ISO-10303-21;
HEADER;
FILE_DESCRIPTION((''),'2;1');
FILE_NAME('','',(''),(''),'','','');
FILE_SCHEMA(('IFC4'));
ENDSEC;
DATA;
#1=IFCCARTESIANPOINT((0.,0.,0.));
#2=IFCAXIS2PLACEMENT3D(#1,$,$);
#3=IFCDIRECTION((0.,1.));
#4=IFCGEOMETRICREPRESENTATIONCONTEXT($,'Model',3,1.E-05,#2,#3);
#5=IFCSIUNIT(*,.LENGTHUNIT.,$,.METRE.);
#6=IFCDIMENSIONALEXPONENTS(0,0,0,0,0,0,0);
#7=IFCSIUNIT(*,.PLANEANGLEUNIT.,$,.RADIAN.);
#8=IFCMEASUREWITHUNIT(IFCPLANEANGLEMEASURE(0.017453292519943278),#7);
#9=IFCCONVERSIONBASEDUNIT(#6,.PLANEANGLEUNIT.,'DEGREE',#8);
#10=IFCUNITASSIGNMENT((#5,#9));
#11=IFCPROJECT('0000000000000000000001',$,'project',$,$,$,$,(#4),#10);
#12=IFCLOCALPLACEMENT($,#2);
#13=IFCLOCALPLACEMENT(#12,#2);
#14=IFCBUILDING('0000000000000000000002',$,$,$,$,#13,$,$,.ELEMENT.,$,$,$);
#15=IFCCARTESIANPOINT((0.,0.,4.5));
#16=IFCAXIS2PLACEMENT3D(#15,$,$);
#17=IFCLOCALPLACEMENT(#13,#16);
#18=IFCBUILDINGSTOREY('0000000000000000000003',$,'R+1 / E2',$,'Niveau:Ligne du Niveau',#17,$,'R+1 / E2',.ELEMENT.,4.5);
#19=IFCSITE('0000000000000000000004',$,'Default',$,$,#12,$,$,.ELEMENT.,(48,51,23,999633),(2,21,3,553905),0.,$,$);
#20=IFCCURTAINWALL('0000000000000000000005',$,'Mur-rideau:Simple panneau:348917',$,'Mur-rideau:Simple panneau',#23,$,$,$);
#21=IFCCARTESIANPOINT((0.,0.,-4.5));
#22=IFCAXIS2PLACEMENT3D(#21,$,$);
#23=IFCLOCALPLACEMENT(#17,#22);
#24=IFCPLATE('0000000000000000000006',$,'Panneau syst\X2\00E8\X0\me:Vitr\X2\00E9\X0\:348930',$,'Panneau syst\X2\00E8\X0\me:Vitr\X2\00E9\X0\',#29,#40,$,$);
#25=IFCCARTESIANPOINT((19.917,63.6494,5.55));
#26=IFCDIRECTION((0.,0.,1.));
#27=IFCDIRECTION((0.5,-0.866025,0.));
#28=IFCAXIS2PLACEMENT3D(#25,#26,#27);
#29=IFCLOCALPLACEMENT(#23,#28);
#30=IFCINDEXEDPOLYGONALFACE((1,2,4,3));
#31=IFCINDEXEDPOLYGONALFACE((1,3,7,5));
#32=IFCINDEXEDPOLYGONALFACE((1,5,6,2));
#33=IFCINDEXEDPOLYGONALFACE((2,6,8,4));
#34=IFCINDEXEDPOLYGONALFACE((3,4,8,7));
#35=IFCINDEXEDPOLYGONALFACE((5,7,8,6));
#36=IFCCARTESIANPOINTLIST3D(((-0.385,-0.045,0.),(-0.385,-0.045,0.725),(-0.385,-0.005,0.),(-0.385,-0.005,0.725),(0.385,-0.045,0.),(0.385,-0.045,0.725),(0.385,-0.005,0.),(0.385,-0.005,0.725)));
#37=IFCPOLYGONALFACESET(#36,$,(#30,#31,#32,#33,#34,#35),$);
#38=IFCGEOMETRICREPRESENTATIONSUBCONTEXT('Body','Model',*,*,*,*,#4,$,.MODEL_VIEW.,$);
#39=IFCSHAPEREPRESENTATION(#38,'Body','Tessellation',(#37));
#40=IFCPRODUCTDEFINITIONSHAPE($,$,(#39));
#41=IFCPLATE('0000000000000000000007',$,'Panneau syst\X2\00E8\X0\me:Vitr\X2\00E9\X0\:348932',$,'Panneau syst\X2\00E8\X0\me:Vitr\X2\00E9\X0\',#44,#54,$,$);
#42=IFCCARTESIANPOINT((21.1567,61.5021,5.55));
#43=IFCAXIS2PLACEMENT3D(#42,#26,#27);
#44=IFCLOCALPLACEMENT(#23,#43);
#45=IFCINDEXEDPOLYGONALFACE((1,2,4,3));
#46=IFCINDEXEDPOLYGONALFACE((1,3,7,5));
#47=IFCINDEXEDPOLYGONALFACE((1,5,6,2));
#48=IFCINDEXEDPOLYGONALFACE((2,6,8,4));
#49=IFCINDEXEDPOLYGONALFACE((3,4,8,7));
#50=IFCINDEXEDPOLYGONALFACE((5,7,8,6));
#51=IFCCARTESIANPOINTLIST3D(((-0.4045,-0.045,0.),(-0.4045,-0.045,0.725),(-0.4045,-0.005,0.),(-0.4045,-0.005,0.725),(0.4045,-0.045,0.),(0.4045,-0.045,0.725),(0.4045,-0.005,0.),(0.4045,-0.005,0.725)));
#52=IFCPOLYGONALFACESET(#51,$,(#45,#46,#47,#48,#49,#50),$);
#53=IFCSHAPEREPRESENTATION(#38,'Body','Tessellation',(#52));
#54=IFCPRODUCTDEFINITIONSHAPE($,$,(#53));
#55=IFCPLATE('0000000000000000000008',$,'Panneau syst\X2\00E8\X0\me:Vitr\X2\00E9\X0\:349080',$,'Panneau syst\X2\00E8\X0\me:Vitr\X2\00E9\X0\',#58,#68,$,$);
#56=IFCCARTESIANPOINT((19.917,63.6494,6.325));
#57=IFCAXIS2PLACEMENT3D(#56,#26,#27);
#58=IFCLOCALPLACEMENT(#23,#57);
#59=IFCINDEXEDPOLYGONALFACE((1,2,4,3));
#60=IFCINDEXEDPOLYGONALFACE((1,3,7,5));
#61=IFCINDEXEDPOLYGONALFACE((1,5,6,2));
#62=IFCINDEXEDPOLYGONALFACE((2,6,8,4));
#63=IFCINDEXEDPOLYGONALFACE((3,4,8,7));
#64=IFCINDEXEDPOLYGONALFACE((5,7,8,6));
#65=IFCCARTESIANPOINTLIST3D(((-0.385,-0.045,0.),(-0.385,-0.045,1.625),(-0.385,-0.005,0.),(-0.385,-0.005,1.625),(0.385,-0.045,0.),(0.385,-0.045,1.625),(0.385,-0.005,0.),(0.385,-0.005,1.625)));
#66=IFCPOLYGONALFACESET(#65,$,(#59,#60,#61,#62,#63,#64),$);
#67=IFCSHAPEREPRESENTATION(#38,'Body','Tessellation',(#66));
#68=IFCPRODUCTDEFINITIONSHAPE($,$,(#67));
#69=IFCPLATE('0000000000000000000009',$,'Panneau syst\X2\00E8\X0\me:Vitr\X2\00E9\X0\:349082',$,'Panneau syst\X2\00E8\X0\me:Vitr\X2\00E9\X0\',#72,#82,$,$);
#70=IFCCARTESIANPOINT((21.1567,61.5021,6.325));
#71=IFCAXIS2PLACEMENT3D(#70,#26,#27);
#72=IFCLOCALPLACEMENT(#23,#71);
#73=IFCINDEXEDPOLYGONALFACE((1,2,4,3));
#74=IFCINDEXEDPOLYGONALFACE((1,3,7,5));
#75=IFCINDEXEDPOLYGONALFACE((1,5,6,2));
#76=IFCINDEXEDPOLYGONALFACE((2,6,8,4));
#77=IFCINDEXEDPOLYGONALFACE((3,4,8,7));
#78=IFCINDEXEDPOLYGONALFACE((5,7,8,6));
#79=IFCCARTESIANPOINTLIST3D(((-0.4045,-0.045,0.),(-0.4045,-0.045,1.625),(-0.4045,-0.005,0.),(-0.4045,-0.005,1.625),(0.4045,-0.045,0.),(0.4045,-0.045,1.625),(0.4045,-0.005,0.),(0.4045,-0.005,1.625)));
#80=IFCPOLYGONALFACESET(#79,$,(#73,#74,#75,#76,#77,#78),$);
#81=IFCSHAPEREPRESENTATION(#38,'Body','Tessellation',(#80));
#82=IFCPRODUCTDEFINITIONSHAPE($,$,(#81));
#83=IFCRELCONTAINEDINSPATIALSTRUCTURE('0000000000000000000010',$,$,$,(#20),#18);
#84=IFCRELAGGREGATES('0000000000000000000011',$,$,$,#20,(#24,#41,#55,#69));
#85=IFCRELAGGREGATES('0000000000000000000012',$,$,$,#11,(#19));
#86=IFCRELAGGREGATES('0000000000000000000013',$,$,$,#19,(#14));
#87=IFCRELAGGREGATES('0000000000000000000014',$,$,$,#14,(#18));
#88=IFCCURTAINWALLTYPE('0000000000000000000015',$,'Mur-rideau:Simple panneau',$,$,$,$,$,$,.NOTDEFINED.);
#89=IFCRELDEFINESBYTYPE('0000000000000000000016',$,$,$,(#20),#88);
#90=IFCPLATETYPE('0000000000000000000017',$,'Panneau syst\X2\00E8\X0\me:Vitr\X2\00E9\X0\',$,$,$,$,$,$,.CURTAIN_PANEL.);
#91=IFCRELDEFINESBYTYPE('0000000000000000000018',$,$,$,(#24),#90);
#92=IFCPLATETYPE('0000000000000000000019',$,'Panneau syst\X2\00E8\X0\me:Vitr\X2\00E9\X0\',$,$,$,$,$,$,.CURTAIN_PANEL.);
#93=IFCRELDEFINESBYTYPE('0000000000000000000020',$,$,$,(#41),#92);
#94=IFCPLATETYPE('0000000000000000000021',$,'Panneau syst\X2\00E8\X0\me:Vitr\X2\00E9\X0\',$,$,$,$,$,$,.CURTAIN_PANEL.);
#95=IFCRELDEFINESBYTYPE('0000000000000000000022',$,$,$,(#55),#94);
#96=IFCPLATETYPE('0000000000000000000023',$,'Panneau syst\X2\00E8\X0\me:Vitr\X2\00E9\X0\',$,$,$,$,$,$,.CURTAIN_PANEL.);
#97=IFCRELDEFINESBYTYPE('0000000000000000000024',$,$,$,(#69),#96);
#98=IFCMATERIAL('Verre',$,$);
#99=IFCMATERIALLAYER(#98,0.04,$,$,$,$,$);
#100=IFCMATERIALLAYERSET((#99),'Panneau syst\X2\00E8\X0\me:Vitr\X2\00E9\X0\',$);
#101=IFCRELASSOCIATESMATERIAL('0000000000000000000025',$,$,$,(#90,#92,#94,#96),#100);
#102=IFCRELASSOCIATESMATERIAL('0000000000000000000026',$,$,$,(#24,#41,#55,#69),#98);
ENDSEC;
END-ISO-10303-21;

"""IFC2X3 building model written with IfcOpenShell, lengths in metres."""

from ifc_helpers import new_model, entity, si_unit, converted_unit, direction, frame, frame_2d, origin, place, context, subcontext, project, spatial, rectangle, extrude, source, transform, mapped, material, layer, layer_set, type_object, type_shapes, element, aggregate, save


model = new_model("IFC2X3")

# Units and contexts
model_context = context("Model", 3, precision=1e-05, world=origin(), true_north=direction((0.0, 1.0)))
body_context = subcontext(model_context, "Body", "Model", "MODEL_VIEW")
ifc_project = project(units=[si_unit("LENGTHUNIT", "METRE"), converted_unit("PLANEANGLEUNIT", "DEGREE", entity("IfcPlaneAngleMeasure", 0.017453292519943278), si_unit("PLANEANGLEUNIT", "RADIAN"), dimensions=[0, 0, 0, 0, 0, 0, 0])], contexts=[model_context])

# Site, building, storey
site_placement = place(None, origin())
site = spatial("IfcSite", under=ifc_project, at=site_placement, Name="Default", CompositionType="ELEMENT", RefLatitude=(48, 51, 23, 999633), RefLongitude=(2, 21, 3, 553905), RefElevation=0.0)
building_placement = place(site_placement, origin())
building = spatial("IfcBuilding", under=site, at=building_placement, CompositionType="ELEMENT")
storey_placement = place(building_placement, frame((0.0, 0.0, 4.5)))
storey = spatial("IfcBuildingStorey", under=building, at=storey_placement, Name="R+1 / E2", ObjectType="Niveau:Ligne du Niveau", LongName="R+1 / E2", CompositionType="ELEMENT", Elevation=4.5)

# Curtain wall
curtain_wall_type = type_object("IfcCurtainWallType", Name="Mur-rideau:Simple panneau", PredefinedType="NOTDEFINED")
curtain_wall_1_placement = place(storey_placement, frame((0.0, 0.0, -4.5)))
curtain_wall_1 = element("IfcCurtainWall", 1, at=curtain_wall_1_placement, inside=storey, type_object=curtain_wall_type, Name="Mur-rideau:Simple panneau:348917", ObjectType="Mur-rideau:Simple panneau")

# Plates
ifc_material_1 = material(Name="Verre")
ifc_layer_1 = layer(ifc_material_1, 0.04)
ifc_layer_set_1 = layer_set([ifc_layer_1], Name="Panneau système:Vitré")
plate_type_1 = type_object("IfcPlateType", Name="Panneau système:Vitré", PredefinedType="CURTAIN_PANEL", material=ifc_layer_set_1)
shared_shape_1 = source(origin(), body_context, "Body", "SweptSolid", [
    extrude(rectangle(XDim=0.04, YDim=0.77, at=frame_2d((0.0, 0.0), x_axis=(1.0, 0.0))), frame((0.0, -0.025, 0.0), z_axis=(0.0, 0.0, 1.0), x_axis=(0.0, 1.0, 0.0)), (0.0, 0.0, 1.0), 0.725),
])
type_shapes(plate_type_1, [shared_shape_1])
plate_1_placement = place(curtain_wall_1_placement, frame((19.917, 63.6494, 5.55), z_axis=(0.0, 0.0, 1.0), x_axis=(0.5, -0.866025, 0.0)))
plate_1 = element("IfcPlate", 2, at=plate_1_placement, type_object=plate_type_1, material=ifc_material_1, Name="Panneau système:Vitré:348930", ObjectType="Panneau système:Vitré", context=body_context, shape_type="MappedRepresentation", body=[
    mapped(shared_shape_1, transform((0.0, 0.0, 0.0), scale=1.0)),
])
plate_type_2 = type_object("IfcPlateType", Name="Panneau système:Vitré", PredefinedType="CURTAIN_PANEL", material=ifc_layer_set_1)
shared_shape_2 = source(origin(), body_context, "Body", "SweptSolid", [
    extrude(rectangle(XDim=0.04, YDim=0.8089, at=frame_2d((0.0, 0.0), x_axis=(1.0, 0.0))), frame((0.0, -0.025, 0.0), z_axis=(0.0, 0.0, 1.0), x_axis=(0.0, 1.0, 0.0)), (0.0, 0.0, 1.0), 0.725),
])
type_shapes(plate_type_2, [shared_shape_2])
plate_2_placement = place(curtain_wall_1_placement, frame((21.1567, 61.5021, 5.55), z_axis=(0.0, 0.0, 1.0), x_axis=(0.5, -0.866025, 0.0)))
plate_2 = element("IfcPlate", 3, at=plate_2_placement, type_object=plate_type_2, material=ifc_material_1, Name="Panneau système:Vitré:348932", ObjectType="Panneau système:Vitré", context=body_context, shape_type="MappedRepresentation", body=[
    mapped(shared_shape_2, transform((0.0, 0.0, 0.0), scale=1.0)),
])
plate_type_3 = type_object("IfcPlateType", Name="Panneau système:Vitré", PredefinedType="CURTAIN_PANEL", material=ifc_layer_set_1)
shared_shape_3 = source(origin(), body_context, "Body", "SweptSolid", [
    extrude(rectangle(XDim=0.04, YDim=0.77, at=frame_2d((0.0, 0.0), x_axis=(1.0, 0.0))), frame((0.0, -0.025, 0.0), z_axis=(0.0, 0.0, 1.0), x_axis=(0.0, 1.0, 0.0)), (0.0, 0.0, 1.0), 1.625),
])
type_shapes(plate_type_3, [shared_shape_3])
plate_3_placement = place(curtain_wall_1_placement, frame((19.917, 63.6494, 6.325), z_axis=(0.0, 0.0, 1.0), x_axis=(0.5, -0.866025, 0.0)))
plate_3 = element("IfcPlate", 4, at=plate_3_placement, type_object=plate_type_3, material=ifc_material_1, Name="Panneau système:Vitré:349080", ObjectType="Panneau système:Vitré", context=body_context, shape_type="MappedRepresentation", body=[
    mapped(shared_shape_3, transform((0.0, 0.0, 0.0), scale=1.0)),
])
plate_type_4 = type_object("IfcPlateType", Name="Panneau système:Vitré", PredefinedType="CURTAIN_PANEL", material=ifc_layer_set_1)
shared_shape_4 = source(origin(), body_context, "Body", "SweptSolid", [
    extrude(rectangle(XDim=0.04, YDim=0.8089, at=frame_2d((0.0, 0.0), x_axis=(1.0, 0.0))), frame((0.0, -0.025, 0.0), z_axis=(0.0, 0.0, 1.0), x_axis=(0.0, 1.0, 0.0)), (0.0, 0.0, 1.0), 1.625),
])
type_shapes(plate_type_4, [shared_shape_4])
plate_4_placement = place(curtain_wall_1_placement, frame((21.1567, 61.5021, 6.325), z_axis=(0.0, 0.0, 1.0), x_axis=(0.5, -0.866025, 0.0)))
plate_4 = element("IfcPlate", 5, at=plate_4_placement, type_object=plate_type_4, material=ifc_material_1, Name="Panneau système:Vitré:349082", ObjectType="Panneau système:Vitré", context=body_context, shape_type="MappedRepresentation", body=[
    mapped(shared_shape_4, transform((0.0, 0.0, 0.0), scale=1.0)),
])
aggregate(curtain_wall_1, [plate_1, plate_2, plate_3, plate_4])

save(model, "model.ifc")
